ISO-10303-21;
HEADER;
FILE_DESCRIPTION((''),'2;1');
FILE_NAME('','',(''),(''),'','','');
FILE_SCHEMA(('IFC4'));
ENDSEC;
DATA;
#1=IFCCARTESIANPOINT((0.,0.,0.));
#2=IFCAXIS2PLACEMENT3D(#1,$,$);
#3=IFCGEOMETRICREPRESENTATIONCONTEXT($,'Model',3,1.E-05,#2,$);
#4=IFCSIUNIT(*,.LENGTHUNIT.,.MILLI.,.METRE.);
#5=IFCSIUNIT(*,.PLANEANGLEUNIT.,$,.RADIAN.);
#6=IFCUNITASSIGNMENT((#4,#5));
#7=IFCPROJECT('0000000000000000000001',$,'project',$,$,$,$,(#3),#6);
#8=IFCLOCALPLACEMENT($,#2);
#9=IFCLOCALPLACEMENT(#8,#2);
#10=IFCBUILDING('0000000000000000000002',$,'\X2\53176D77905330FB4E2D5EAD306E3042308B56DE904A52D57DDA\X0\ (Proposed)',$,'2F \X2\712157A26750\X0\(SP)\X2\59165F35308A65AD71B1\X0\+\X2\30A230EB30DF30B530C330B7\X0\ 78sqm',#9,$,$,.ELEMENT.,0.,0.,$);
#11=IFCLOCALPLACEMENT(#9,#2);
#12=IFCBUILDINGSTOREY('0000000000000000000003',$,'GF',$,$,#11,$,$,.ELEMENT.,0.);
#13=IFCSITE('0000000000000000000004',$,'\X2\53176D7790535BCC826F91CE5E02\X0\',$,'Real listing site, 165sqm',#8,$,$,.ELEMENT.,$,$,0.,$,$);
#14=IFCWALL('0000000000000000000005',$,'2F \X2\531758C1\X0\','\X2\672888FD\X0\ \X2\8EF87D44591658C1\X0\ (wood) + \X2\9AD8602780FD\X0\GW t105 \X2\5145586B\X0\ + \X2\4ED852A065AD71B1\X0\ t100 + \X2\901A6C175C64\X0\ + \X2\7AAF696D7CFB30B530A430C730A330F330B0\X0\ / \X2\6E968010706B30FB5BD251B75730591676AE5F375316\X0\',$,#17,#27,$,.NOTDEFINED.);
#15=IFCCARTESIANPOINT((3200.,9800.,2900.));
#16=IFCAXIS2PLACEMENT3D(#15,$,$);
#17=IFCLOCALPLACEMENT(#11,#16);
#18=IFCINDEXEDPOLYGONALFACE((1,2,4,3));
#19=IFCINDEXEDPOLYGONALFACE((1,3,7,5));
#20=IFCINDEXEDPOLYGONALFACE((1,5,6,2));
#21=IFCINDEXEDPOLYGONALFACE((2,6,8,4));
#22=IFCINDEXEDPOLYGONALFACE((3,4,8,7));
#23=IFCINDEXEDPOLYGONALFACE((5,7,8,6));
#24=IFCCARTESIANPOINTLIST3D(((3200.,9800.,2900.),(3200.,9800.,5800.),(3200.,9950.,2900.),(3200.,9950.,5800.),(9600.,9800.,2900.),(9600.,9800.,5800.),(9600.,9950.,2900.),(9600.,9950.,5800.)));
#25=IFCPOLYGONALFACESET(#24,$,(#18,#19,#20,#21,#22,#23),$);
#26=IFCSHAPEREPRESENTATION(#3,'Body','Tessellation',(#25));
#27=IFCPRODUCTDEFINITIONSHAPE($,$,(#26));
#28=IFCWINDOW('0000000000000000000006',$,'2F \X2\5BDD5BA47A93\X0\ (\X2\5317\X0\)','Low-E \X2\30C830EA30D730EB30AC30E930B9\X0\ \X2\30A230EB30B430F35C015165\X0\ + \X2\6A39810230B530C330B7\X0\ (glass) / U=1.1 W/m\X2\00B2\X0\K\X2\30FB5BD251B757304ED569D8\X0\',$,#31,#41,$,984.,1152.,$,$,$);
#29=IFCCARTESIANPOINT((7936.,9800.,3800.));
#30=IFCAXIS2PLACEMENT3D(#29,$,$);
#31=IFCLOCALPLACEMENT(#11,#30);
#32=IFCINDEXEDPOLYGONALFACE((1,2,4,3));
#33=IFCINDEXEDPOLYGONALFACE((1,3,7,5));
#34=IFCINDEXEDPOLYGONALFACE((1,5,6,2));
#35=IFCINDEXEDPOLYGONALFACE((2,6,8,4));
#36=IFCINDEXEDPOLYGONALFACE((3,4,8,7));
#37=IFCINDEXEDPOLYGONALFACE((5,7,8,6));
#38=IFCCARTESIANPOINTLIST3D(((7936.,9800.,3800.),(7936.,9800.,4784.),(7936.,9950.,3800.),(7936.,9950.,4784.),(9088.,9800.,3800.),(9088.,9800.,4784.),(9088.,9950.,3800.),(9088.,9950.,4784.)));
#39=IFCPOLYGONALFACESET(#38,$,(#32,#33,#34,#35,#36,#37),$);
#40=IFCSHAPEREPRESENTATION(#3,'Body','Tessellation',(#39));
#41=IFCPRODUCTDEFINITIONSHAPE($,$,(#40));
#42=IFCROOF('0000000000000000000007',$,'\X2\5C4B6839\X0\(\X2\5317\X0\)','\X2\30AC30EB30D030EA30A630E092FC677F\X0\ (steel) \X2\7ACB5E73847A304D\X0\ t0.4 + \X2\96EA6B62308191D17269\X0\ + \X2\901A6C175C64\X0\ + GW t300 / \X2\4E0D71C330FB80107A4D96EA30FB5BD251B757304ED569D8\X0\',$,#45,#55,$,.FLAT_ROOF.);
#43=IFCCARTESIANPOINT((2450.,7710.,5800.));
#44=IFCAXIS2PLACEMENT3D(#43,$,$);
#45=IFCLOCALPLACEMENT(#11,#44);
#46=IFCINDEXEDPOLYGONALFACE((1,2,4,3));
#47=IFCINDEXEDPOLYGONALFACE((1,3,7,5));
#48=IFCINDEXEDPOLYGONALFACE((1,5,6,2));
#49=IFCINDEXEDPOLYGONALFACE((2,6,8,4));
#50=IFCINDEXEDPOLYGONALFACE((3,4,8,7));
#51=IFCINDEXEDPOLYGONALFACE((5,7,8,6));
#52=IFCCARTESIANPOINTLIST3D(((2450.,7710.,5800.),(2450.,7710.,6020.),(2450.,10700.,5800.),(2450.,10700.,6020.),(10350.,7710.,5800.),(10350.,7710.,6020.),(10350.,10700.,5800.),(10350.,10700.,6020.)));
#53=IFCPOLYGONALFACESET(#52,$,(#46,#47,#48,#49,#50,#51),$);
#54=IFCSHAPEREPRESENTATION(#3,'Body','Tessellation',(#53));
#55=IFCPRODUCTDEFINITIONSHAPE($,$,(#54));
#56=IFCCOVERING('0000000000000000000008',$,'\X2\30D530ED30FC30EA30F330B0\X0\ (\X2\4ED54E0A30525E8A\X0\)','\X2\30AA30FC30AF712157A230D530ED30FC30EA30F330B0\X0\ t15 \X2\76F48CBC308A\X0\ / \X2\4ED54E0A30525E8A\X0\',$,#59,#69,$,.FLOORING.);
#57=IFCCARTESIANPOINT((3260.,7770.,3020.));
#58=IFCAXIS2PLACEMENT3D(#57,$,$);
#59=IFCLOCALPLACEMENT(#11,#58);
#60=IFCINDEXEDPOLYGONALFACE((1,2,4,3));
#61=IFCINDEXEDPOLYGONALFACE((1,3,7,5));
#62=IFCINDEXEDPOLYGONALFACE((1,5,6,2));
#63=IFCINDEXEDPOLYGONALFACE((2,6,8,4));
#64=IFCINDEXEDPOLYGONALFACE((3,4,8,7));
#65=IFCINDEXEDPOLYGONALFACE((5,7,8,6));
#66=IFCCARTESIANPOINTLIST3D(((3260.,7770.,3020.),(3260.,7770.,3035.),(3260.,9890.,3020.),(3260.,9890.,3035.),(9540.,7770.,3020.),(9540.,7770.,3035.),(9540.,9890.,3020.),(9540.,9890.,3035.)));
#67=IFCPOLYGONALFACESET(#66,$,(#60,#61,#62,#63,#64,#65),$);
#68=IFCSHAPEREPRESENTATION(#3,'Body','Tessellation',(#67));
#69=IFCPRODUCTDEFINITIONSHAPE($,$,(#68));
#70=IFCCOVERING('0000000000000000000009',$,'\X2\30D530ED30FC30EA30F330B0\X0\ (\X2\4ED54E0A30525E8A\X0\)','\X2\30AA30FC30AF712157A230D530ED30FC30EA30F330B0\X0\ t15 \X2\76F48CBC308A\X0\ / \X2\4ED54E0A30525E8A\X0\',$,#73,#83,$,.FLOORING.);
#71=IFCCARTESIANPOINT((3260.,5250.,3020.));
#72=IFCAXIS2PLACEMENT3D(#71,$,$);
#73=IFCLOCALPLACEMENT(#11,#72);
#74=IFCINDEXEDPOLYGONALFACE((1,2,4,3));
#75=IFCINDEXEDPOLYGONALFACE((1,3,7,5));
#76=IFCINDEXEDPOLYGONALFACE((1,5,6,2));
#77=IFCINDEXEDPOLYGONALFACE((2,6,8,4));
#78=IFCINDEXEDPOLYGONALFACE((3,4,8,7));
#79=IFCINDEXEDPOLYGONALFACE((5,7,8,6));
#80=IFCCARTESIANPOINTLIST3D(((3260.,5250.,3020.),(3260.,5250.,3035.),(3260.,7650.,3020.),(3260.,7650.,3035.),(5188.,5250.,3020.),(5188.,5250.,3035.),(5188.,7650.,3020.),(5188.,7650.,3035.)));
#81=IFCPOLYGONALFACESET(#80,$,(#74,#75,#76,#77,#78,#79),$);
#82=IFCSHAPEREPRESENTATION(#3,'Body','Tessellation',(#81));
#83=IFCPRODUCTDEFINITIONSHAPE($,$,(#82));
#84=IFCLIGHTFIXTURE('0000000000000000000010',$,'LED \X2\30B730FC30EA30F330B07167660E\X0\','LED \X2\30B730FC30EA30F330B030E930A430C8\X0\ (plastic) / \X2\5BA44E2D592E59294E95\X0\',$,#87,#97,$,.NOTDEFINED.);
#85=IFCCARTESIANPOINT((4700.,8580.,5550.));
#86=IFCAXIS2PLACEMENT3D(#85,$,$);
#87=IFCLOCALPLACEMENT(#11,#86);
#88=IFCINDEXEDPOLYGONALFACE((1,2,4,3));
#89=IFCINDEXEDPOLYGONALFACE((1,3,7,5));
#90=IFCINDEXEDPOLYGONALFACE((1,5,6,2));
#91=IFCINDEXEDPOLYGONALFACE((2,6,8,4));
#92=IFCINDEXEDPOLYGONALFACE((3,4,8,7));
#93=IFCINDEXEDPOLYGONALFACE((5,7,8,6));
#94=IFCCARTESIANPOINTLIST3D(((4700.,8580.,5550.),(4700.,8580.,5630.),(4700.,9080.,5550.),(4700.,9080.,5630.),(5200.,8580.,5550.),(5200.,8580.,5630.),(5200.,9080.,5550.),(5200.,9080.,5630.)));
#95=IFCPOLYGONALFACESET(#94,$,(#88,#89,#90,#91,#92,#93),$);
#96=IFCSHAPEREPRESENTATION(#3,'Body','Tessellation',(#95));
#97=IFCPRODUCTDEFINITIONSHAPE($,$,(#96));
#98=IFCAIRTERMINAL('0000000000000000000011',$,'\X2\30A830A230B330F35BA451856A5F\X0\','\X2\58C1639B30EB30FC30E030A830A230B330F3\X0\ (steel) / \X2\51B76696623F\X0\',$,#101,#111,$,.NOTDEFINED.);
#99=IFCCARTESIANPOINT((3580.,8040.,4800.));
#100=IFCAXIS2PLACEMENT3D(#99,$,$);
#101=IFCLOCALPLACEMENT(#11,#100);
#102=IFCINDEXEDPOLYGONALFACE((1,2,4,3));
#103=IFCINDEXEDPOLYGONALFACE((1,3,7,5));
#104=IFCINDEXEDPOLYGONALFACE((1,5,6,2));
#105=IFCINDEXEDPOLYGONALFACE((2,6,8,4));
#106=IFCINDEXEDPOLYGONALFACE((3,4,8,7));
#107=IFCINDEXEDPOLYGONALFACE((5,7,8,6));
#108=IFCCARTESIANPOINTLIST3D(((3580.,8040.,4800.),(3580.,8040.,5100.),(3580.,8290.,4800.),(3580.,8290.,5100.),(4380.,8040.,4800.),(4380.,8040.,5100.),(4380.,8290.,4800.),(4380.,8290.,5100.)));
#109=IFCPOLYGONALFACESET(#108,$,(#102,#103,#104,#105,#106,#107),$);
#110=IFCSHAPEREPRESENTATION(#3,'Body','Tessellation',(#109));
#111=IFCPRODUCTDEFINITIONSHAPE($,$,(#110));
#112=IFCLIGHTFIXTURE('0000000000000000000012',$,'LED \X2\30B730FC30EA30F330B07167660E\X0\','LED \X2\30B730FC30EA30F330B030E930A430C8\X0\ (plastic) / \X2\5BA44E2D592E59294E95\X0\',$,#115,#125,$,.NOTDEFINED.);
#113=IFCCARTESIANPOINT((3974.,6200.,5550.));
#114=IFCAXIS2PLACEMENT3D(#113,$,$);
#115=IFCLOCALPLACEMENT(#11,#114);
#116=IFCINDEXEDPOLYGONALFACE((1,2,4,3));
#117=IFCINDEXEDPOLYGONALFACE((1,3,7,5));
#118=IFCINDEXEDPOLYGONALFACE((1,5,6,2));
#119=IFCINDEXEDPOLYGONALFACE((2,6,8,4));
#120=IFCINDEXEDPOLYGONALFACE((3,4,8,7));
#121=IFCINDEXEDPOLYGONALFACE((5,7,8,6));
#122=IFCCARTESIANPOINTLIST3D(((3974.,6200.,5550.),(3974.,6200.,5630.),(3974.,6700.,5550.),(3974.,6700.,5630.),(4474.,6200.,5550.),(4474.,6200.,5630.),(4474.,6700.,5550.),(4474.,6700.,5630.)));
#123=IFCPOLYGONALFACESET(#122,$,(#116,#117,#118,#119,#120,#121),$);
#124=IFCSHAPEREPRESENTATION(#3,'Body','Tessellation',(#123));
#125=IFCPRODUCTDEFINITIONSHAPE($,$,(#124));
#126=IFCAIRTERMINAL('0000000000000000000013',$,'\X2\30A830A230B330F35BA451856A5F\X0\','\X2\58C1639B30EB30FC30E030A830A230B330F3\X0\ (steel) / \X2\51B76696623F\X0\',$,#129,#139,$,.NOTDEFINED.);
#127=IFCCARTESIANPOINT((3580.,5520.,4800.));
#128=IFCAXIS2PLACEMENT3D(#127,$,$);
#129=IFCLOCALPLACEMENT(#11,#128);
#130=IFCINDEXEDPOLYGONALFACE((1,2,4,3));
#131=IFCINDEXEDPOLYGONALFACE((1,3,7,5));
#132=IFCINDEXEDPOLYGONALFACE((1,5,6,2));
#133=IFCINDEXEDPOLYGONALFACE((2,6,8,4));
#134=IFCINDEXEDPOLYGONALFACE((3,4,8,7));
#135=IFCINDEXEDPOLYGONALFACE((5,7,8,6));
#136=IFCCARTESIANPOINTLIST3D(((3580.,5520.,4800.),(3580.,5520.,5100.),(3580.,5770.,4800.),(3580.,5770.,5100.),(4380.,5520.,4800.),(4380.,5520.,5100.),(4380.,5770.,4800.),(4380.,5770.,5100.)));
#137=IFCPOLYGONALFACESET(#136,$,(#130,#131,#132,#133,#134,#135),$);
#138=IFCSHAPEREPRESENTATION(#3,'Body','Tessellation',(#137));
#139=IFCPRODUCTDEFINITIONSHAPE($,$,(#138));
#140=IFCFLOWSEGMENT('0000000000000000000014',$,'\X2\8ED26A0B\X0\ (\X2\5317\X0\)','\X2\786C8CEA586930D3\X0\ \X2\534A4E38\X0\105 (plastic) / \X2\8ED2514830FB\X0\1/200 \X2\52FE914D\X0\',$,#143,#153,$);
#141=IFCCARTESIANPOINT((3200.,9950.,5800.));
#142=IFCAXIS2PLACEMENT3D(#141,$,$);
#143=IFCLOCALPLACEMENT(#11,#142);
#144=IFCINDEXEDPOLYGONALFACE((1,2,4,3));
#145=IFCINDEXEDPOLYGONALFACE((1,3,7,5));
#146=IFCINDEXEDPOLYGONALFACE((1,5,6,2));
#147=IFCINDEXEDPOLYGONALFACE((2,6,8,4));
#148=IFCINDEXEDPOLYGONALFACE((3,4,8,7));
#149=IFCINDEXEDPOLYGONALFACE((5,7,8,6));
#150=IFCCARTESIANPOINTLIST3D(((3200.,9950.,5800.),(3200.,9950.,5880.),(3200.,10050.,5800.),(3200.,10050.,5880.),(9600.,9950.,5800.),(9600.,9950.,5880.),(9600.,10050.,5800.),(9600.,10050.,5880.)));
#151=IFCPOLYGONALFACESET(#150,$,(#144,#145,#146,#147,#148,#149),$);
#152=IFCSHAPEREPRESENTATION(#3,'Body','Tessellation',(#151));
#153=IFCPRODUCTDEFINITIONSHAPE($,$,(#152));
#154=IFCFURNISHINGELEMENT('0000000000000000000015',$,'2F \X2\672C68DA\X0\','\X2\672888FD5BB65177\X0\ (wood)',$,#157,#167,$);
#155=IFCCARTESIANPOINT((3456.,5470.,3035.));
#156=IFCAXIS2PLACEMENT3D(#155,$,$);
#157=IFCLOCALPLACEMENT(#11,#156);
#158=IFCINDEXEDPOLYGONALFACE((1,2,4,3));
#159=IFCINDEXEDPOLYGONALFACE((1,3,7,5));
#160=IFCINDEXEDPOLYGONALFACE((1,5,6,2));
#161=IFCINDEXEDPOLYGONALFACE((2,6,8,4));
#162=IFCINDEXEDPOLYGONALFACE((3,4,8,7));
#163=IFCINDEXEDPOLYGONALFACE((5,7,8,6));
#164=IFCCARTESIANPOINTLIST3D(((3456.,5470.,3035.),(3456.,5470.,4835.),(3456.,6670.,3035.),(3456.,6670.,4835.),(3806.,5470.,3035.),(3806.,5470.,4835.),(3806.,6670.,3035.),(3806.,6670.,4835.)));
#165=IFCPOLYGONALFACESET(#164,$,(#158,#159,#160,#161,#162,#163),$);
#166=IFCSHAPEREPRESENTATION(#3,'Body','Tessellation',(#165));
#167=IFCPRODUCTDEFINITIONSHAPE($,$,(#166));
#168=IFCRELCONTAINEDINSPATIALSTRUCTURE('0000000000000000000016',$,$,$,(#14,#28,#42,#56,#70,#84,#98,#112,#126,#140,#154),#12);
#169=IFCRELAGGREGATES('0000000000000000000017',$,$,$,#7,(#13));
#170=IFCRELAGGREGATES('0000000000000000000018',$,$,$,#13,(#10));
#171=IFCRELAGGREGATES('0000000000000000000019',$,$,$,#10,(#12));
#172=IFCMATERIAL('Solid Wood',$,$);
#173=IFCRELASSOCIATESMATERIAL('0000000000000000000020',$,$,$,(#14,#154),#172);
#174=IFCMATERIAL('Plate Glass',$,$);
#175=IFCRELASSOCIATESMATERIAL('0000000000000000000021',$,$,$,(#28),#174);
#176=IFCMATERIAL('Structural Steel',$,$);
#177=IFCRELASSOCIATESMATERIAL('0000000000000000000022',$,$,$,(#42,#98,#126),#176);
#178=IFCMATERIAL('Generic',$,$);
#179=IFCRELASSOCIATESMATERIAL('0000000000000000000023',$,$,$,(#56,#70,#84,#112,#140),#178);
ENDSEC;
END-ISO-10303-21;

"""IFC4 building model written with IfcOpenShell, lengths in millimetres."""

from ifc_helpers import new_model, si_unit, frame, frame_2d, origin, place, context, project, spatial, rectangle, extrude, material, element, fill, save


model = new_model("IFC4")

# Units and contexts
model_context = context("Model", 3, precision=1e-05, world=origin())
ifc_project = project(units=[si_unit("LENGTHUNIT", "METRE", prefix="MILLI"), si_unit("PLANEANGLEUNIT", "RADIAN")], contexts=[model_context])

# Site, building, storey
site_placement = place(None, origin())
site = spatial("IfcSite", under=ifc_project, at=site_placement, Name="北海道富良野市", ObjectType="Real listing site, 165sqm", CompositionType="ELEMENT", RefElevation=0.0)
building_placement = place(site_placement, origin())
building = spatial("IfcBuilding", under=site, at=building_placement, Name="北海道・中庭のある回遊動線 (Proposed)", ObjectType="2F 無垢材(SP)外張り断熱+アルミサッシ 78sqm", CompositionType="ELEMENT", ElevationOfRefHeight=0.0, ElevationOfTerrain=0.0)
storey_placement = place(building_placement, origin())
storey = spatial("IfcBuildingStorey", under=building, at=storey_placement, Name="GF", CompositionType="ELEMENT", Elevation=0.0)

# Shared definitions
ifc_material_1 = material(Name="Solid Wood")

# Wall, opening, window
wall_placement = place(storey_placement, frame((3200.0, 9800.0, 2900.0)))
wall = element("IfcWall", 1, at=wall_placement, inside=storey, material=ifc_material_1, Name="2F 北壁", Description="木製 軸組外壁 (wood) + 高性能GW t105 充填 + 付加断熱 t100 + 通気層 + 窯業系サイディング / 準耐火・寒冷地外皮強化", PredefinedType="NOTDEFINED", context=model_context, shape_type="SweptSolid", body=[
    extrude(rectangle(XDim=6400.0, YDim=150.0, at=frame_2d((3200.0, 75.0))), frame((3200.0, 9800.0, 2900.0)), (0.0, 0.0, 1.0), 2900.0),
])
opening_placement = place(storey_placement, frame((7936.0, 9800.0, 3800.0)))
opening = element("IfcOpeningElement", 2, at=opening_placement, cuts=wall, PredefinedType="NOTDEFINED", context=model_context, shape_type="SweptSolid", body=[
    extrude(rectangle(XDim=1152.0, YDim=150.0, at=frame_2d((576.0, 75.0))), frame((7936.0, 9800.0, 3800.0)), (0.0, 0.0, 1.0), 984.0),
])
ifc_material_2 = material(Name="Plate Glass")
window_placement = place(storey_placement, frame((7936.0, 9800.0, 3800.0)))
window = element("IfcWindow", 3, at=window_placement, inside=storey, material=ifc_material_2, Name="2F 寝室窓 (北)", Description="Low-E トリプルガラス アルゴン封入 + 樹脂サッシ (glass) / U=1.1 W/m²K・寒冷地仕様", OverallHeight=984.0, OverallWidth=1152.0, context=model_context, shape_type="SweptSolid", body=[
    extrude(rectangle(XDim=1152.0, YDim=150.0, at=frame_2d((576.0, 75.0))), frame((7936.0, 9800.0, 3800.0)), (0.0, 0.0, 1.0), 984.0),
])
fill(opening, window)

# Roof
ifc_material_3 = material(Name="Structural Steel")
for number, where, name in (
    (4, (2450.0, 7710.0, 5800.0), "屋根(北)"),
):
    element("IfcRoof", number, at=place(storey_placement, frame(where)), inside=storey, material=ifc_material_3, Name=name, Description="ガルバリウム鋼板 (steel) 立平葺き t0.4 + 雪止め金物 + 通気層 + GW t300 / 不燃・耐積雪・寒冷地仕様", PredefinedType="FLAT_ROOF", context=model_context, shape_type="SweptSolid", body=[
        extrude(rectangle(XDim=7900.0, YDim=2990.0, at=frame_2d((3950.0, 1495.0))), frame((2450.0, 7710.0, 5800.0)), (0.0, 0.0, 1.0), 220.0),
    ])

# Coverings
ifc_material_4 = material(Name="Generic")
covering_1_placement = place(storey_placement, frame((3260.0, 7770.0, 3020.0)))
element("IfcCovering", 5, at=covering_1_placement, inside=storey, material=ifc_material_4, Name="フローリング (仕上げ床)", Description="オーク無垢フローリング t15 直貼り / 仕上げ床", PredefinedType="FLOORING", context=model_context, shape_type="SweptSolid", body=[
    extrude(rectangle(XDim=6280.0, YDim=2120.0, at=frame_2d((3140.0, 1060.0))), frame((3260.0, 7770.0, 3020.0)), (0.0, 0.0, 1.0), 15.0),
])
covering_2_placement = place(storey_placement, frame((3260.0, 5250.0, 3020.0)))
element("IfcCovering", 6, at=covering_2_placement, inside=storey, material=ifc_material_4, Name="フローリング (仕上げ床)", Description="オーク無垢フローリング t15 直貼り / 仕上げ床", PredefinedType="FLOORING", context=model_context, shape_type="SweptSolid", body=[
    extrude(rectangle(XDim=1928.0, YDim=2400.0, at=frame_2d((964.0, 1200.0))), frame((3260.0, 5250.0, 3020.0)), (0.0, 0.0, 1.0), 15.0),
])

# Light fixture
light_fixture_1_placement = place(storey_placement, frame((4700.0, 8580.0, 5550.0)))
element("IfcLightFixture", 7, at=light_fixture_1_placement, inside=storey, material=ifc_material_4, Name="LED シーリング照明", Description="LED シーリングライト (plastic) / 室中央天井", PredefinedType="NOTDEFINED", context=model_context, shape_type="SweptSolid", body=[
    extrude(rectangle(XDim=500.0, YDim=500.0, at=frame_2d((250.0, 250.0))), frame((4700.0, 8580.0, 5550.0)), (0.0, 0.0, 1.0), 80.0),
])

# Air terminal
air_terminal_1_placement = place(storey_placement, frame((3580.0, 8040.0, 4800.0)))
element("IfcAirTerminal", 8, at=air_terminal_1_placement, inside=storey, material=ifc_material_3, Name="エアコン室内機", Description="壁掛ルームエアコン (steel) / 冷暖房", PredefinedType="NOTDEFINED", context=model_context, shape_type="SweptSolid", body=[
    extrude(rectangle(XDim=800.0, YDim=250.0, at=frame_2d((400.0, 125.0))), frame((3580.0, 8040.0, 4800.0)), (0.0, 0.0, 1.0), 300.0),
])

# Light fixture
light_fixture_2_placement = place(storey_placement, frame((3974.0, 6200.0, 5550.0)))
element("IfcLightFixture", 9, at=light_fixture_2_placement, inside=storey, material=ifc_material_4, Name="LED シーリング照明", Description="LED シーリングライト (plastic) / 室中央天井", PredefinedType="NOTDEFINED", context=model_context, shape_type="SweptSolid", body=[
    extrude(rectangle(XDim=500.0, YDim=500.0, at=frame_2d((250.0, 250.0))), frame((3974.0, 6200.0, 5550.0)), (0.0, 0.0, 1.0), 80.0),
])

# Air terminal
air_terminal_2_placement = place(storey_placement, frame((3580.0, 5520.0, 4800.0)))
element("IfcAirTerminal", 10, at=air_terminal_2_placement, inside=storey, material=ifc_material_3, Name="エアコン室内機", Description="壁掛ルームエアコン (steel) / 冷暖房", PredefinedType="NOTDEFINED", context=model_context, shape_type="SweptSolid", body=[
    extrude(rectangle(XDim=800.0, YDim=250.0, at=frame_2d((400.0, 125.0))), frame((3580.0, 5520.0, 4800.0)), (0.0, 0.0, 1.0), 300.0),
])

# Flow segment
flow_segment_placement = place(storey_placement, frame((3200.0, 9950.0, 5800.0)))
element("IfcFlowSegment", 11, at=flow_segment_placement, inside=storey, material=ifc_material_4, Name="軒樋 (北)", Description="硬質塩ビ 半丸105 (plastic) / 軒先・1/200 勾配", context=model_context, shape_type="SweptSolid", body=[
    extrude(rectangle(XDim=6400.0, YDim=100.0, at=frame_2d((3200.0, 50.0))), frame((3200.0, 9950.0, 5800.0)), (0.0, 0.0, 1.0), 80.0),
])

# Furnishing element
furnishing_placement = place(storey_placement, frame((3456.0, 5470.0, 3035.0)))
element("IfcFurnishingElement", 12, at=furnishing_placement, inside=storey, material=ifc_material_1, Name="2F 本棚", Description="木製家具 (wood)", context=model_context, shape_type="SweptSolid", body=[
    extrude(rectangle(XDim=350.0, YDim=1200.0, at=frame_2d((175.0, 600.0))), frame((3456.0, 5470.0, 3035.0)), (0.0, 0.0, 1.0), 1800.0),
])

save(model, "model.ifc")
